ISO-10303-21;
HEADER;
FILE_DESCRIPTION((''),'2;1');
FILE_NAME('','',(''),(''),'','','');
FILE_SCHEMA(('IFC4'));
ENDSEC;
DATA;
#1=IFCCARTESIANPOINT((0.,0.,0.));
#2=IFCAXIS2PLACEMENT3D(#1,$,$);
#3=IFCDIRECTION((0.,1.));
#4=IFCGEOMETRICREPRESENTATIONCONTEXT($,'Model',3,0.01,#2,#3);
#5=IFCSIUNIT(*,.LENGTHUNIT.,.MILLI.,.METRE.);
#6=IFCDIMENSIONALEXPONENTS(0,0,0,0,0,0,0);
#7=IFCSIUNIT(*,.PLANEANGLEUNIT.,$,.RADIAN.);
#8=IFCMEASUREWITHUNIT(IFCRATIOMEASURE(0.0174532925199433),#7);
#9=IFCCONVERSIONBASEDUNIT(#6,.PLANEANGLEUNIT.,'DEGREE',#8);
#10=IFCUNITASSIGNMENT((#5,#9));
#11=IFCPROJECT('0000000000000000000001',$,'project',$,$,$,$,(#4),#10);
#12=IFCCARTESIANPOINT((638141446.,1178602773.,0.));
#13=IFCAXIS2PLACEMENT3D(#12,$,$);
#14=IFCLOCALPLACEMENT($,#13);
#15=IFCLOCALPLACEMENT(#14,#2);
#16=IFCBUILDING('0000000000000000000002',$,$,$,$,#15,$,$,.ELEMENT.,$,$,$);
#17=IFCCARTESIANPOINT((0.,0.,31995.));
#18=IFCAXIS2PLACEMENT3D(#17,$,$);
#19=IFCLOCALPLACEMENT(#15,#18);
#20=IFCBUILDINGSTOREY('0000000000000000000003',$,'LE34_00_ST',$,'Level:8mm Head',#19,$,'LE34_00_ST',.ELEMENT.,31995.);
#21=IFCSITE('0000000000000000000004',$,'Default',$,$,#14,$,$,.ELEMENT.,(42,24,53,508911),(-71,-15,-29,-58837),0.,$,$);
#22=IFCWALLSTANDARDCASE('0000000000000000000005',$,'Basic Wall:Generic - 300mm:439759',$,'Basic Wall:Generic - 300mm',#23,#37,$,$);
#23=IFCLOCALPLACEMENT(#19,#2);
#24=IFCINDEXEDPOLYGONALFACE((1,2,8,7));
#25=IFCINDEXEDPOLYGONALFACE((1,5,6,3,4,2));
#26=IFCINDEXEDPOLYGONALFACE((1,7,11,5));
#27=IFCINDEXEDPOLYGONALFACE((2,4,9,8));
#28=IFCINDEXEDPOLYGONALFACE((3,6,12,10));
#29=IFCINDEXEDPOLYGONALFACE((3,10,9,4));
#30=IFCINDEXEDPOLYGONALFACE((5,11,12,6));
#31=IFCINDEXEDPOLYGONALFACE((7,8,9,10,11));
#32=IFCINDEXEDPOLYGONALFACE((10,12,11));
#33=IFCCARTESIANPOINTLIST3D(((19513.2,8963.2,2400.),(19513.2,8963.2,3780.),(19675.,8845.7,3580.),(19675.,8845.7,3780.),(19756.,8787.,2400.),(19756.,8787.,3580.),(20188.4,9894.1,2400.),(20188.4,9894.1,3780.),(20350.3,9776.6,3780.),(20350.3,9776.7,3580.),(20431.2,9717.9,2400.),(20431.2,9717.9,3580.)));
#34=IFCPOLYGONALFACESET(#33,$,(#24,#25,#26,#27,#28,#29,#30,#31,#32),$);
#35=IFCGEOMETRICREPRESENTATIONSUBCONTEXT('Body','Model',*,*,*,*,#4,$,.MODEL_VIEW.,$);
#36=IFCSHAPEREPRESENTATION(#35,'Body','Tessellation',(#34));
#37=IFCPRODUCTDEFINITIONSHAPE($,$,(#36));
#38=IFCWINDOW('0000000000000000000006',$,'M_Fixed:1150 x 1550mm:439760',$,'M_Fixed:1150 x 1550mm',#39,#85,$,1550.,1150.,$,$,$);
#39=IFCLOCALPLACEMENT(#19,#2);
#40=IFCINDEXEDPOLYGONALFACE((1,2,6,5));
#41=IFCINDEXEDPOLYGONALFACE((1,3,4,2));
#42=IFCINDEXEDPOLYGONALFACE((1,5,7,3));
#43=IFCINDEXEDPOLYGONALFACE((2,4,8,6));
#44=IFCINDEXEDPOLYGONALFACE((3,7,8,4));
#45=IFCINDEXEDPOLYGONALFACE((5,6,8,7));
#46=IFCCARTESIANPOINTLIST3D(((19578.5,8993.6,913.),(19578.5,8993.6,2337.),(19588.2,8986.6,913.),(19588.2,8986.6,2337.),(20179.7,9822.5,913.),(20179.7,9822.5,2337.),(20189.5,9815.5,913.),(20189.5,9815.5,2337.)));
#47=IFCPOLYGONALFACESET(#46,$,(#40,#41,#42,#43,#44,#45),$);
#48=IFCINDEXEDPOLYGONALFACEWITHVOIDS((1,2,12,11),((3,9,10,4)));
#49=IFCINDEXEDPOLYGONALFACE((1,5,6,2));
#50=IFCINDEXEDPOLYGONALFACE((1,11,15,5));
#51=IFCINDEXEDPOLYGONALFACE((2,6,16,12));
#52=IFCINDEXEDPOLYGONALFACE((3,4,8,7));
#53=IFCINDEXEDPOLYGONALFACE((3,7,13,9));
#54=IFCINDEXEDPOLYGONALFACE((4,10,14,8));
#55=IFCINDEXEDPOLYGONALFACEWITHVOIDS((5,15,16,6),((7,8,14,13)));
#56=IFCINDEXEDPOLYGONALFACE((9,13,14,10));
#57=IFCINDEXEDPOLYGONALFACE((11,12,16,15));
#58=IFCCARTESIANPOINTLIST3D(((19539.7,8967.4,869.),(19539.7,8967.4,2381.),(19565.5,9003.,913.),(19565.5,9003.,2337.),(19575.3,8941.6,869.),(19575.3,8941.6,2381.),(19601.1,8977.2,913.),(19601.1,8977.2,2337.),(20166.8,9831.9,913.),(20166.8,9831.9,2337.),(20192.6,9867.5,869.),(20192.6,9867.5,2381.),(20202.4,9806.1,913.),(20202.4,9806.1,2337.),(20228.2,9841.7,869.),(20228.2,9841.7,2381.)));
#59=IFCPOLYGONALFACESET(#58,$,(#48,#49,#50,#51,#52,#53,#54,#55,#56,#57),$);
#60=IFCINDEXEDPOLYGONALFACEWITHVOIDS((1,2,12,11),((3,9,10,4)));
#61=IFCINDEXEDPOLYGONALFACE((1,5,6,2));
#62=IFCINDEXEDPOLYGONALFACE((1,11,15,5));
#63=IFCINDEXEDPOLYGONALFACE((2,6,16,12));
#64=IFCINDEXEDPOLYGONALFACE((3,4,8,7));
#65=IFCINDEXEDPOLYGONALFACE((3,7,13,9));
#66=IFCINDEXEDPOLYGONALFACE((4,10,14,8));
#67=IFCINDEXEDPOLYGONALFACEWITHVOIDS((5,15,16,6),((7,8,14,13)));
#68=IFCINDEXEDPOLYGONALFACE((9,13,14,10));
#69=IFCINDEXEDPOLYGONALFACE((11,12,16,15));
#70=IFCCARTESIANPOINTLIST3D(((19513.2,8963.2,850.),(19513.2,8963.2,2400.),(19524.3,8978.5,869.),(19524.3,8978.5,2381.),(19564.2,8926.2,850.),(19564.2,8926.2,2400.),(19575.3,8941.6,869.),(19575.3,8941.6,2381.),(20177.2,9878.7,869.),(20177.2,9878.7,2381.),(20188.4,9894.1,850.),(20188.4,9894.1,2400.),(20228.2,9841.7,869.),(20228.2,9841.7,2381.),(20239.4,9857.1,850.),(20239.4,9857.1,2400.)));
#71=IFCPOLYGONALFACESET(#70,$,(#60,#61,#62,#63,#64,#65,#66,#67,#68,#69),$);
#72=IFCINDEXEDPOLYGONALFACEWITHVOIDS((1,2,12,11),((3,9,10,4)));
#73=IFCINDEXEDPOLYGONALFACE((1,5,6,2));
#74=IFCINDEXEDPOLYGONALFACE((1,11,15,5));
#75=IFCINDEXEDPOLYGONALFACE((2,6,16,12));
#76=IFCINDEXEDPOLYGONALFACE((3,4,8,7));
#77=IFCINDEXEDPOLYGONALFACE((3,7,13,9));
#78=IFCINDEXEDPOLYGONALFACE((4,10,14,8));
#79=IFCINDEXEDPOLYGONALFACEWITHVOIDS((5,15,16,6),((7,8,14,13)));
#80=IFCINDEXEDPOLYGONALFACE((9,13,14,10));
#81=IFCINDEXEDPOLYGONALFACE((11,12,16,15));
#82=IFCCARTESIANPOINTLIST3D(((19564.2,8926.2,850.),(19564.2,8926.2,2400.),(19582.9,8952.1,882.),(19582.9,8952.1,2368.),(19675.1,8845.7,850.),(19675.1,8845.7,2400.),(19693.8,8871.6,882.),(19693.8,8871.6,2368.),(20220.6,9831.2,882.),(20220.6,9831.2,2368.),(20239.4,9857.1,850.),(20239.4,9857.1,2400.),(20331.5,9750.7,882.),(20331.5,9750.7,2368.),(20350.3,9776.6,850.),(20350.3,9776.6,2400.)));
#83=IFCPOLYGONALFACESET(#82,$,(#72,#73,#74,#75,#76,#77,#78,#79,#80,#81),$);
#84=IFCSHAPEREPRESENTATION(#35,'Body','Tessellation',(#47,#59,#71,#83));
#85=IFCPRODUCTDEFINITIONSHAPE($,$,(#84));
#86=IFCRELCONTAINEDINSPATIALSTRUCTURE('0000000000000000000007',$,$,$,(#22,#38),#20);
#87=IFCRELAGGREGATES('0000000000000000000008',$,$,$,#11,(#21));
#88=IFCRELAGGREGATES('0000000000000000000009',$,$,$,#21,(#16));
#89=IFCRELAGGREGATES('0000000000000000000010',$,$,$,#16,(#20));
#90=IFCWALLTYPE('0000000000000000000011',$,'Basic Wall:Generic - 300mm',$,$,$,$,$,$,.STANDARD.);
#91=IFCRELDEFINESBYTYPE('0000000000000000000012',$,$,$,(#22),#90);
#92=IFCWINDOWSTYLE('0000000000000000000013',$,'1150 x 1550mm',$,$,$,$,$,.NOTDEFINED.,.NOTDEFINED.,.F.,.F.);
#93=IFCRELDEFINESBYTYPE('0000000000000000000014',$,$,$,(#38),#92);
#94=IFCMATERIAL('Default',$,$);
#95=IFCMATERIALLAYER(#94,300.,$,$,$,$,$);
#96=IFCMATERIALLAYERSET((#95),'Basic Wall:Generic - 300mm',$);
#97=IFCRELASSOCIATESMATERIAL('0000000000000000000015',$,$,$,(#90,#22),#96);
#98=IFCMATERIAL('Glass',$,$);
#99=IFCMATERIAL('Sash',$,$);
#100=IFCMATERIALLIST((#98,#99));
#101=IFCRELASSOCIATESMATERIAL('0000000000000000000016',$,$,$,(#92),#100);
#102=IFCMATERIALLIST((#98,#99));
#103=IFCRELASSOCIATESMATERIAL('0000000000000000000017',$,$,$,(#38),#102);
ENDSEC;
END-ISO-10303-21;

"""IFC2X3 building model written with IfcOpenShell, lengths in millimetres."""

from ifc_helpers import new_model, entity, si_unit, converted_unit, direction, frame, frame_2d, origin, place, context, subcontext, project, spatial, polyline, rectangle, outline, extrude, clip, bounded_halfspace, source, transform, mapped, material, material_list, layer, layer_set, layer_usage, type_object, type_shapes, element, fill, save


model = new_model("IFC2X3")

# Units and contexts
model_context = context("Model", 3, precision=0.01, world=origin(), true_north=direction((0.0, 1.0)))
body_context = subcontext(model_context, "Body", "Model", "MODEL_VIEW")
ifc_project = project(units=[si_unit("LENGTHUNIT", "METRE", prefix="MILLI"), converted_unit("PLANEANGLEUNIT", "DEGREE", entity("IfcRatioMeasure", 0.0174532925199433), si_unit("PLANEANGLEUNIT", "RADIAN"), dimensions=[0, 0, 0, 0, 0, 0, 0])], contexts=[model_context])

# Site, building, storey
site_placement = place(None, frame((638141446.0, 1178602773.0, 0.0)))
site = spatial("IfcSite", under=ifc_project, at=site_placement, Name="Default", CompositionType="ELEMENT", RefLatitude=(42, 24, 53, 508911), RefLongitude=(-71, -15, -29, -58837), RefElevation=0.0)
building_placement = place(site_placement, origin())
building = spatial("IfcBuilding", under=site, at=building_placement, CompositionType="ELEMENT")
storey_placement = place(building_placement, frame((0.0, 0.0, 31995.0)))
storey = spatial("IfcBuildingStorey", under=building, at=storey_placement, Name="LE34_00_ST", ObjectType="Level:8mm Head", LongName="LE34_00_ST", CompositionType="ELEMENT", Elevation=31995.0)

# Wall, opening, window
ifc_material_1 = material(Name="Default")
ifc_layer = layer(ifc_material_1, 300.0)
ifc_layer_set = layer_set([ifc_layer], Name="Basic Wall:Generic - 300mm")
ifc_layer_usage = layer_usage(ifc_layer_set, "AXIS2", "NEGATIVE", 150.0)
wall_type = type_object("IfcWallType", Name="Basic Wall:Generic - 300mm", PredefinedType="STANDARD", material=ifc_layer_set)
wall_placement = place(storey_placement, frame((19634.6, 8875.1, 2400.0), z_axis=(0.0, 0.0, 1.0), x_axis=(0.587164, 0.809468, 0.0)))
wall = element("IfcWallStandardCase", 1, at=wall_placement, inside=storey, type_object=wall_type, material=ifc_layer_usage, Name="Basic Wall:Generic - 300mm:439759", ObjectType="Basic Wall:Generic - 300mm", context=body_context, shape_type="Clipping", body=[
    clip(clip(extrude(rectangle(XDim=1150.0, YDim=300.0, at=frame_2d((575.0, 0.0), x_axis=(-1.0, 0.0))), origin(), (0.0, 0.0, 1.0), 1380.0), bounded_halfspace(frame((1150.1, -50.0, 1180.0), z_axis=(0.0, 0.0, -1.0), x_axis=(0.0, 1.0, 0.0)), True, frame((1150.1, -50.0, 1180.0), z_axis=(0.0, 0.0, -1.0), x_axis=(0.0, 1.0, 0.0)), polyline([(0.0, 0.0), (-100.0, -0.1), (-100.0, -1150.1), (0.0, -1150.1), (0.0, 0.0)]))), bounded_halfspace(frame((0.0, -50.0, 1180.0), z_axis=(0.00002, 1.0, 0.0), x_axis=(0.0, 0.0, 1.0)), True, frame((0.0, -50.0, 1180.0), z_axis=(0.00002, 1.0, 0.0), x_axis=(0.0, 0.0, 1.0)), polyline([(0.0, 0.0), (200.0, 0.0), (200.0, 1150.0), (0.0, 1150.1), (0.0, 0.0)]))),
])
opening_placement = place(wall_placement, frame((0.0, -150.0, -1550.0)))
opening = element("IfcOpeningElement", 2, at=opening_placement, cuts=wall, ObjectType="Opening", context=body_context, shape_type="SweptSolid", body=[
    extrude(rectangle(XDim=1550.0, YDim=1150.0, at=frame_2d((775.0, 575.0), x_axis=(1.0, 0.0))), frame((0.0, 0.0, 0.0), z_axis=(0.0, 1.0, 0.0), x_axis=(0.0, 0.0, 1.0)), (0.0, 0.0, 1.0), 300.0),
])
ifc_material_2 = material(Name="Glass")
ifc_material_3 = material(Name="Sash")
ifc_material_list_1 = material_list([ifc_material_2, ifc_material_3])
ifc_material_list_2 = material_list([ifc_material_2, ifc_material_3])
window_style = type_object("IfcWindowStyle", Name="1150 x 1550mm", ConstructionType="NOTDEFINED", OperationType="NOTDEFINED", ParameterTakesPrecedence=False, Sizeable=False, material=ifc_material_list_2)
shared_shape_1 = source(origin(), body_context, "Body", "SweptSolid", [
    extrude(rectangle(XDim=12.0, YDim=1024.0, at=frame_2d((0.0, 0.0), x_axis=(1.0, 0.0))), frame((575.0, 259.0, 63.0), z_axis=(0.0, 0.0, 1.0), x_axis=(0.0, -1.0, 0.0)), (0.0, 0.0, 1.0), 1424.0),
    extrude(outline(polyline([(-556.0, -756.0), (556.0, -756.0), (556.0, 756.0), (-556.0, 756.0), (-556.0, -756.0)]), holes=[polyline([(-512.0, -712.0), (-512.0, 712.0), (512.0, 712.0), (512.0, -712.0), (-512.0, -712.0)])]), frame((575.0, 237.0, 775.0), z_axis=(0.0, 1.0, 0.0), x_axis=(1.0, 0.0, 0.0)), (0.0, 0.0, 1.0), 44.0),
    extrude(outline(polyline([(-575.0, -775.0), (575.0, -775.0), (575.0, 775.0), (-575.0, 775.0), (-575.0, -775.0)]), holes=[polyline([(-556.0, -756.0), (-556.0, 756.0), (556.0, 756.0), (556.0, -756.0), (-556.0, -756.0)])]), frame((575.0, 237.0, 775.0), z_axis=(0.0, 1.0, 0.0), x_axis=(1.0, 0.0, 0.0)), (0.0, 0.0, 1.0), 63.0),
    extrude(outline(polyline([(-575.0, -775.0), (575.0, -775.0), (575.0, 775.0), (-575.0, 775.0), (-575.0, -775.0)]), holes=[polyline([(-543.0, -743.0), (-543.0, 743.0), (543.0, 743.0), (543.0, -743.0), (-543.0, -743.0)])]), frame((575.0, 100.0, 775.0), z_axis=(0.0, 1.0, 0.0), x_axis=(1.0, 0.0, 0.0)), (0.0, 0.0, 1.0), 137.0),
])
type_shapes(window_style, [shared_shape_1])
window_placement = place(opening_placement, origin())
window = element("IfcWindow", 3, at=window_placement, inside=storey, type_object=window_style, material=ifc_material_list_1, Name="M_Fixed:1150 x 1550mm:439760", ObjectType="M_Fixed:1150 x 1550mm", OverallHeight=1550.0, OverallWidth=1150.0, context=body_context, shape_type="MappedRepresentation", body=[
    mapped(shared_shape_1, transform((0.0, 0.0, 0.0), scale=1.0)),
])
fill(opening, window)

save(model, "model.ifc")
